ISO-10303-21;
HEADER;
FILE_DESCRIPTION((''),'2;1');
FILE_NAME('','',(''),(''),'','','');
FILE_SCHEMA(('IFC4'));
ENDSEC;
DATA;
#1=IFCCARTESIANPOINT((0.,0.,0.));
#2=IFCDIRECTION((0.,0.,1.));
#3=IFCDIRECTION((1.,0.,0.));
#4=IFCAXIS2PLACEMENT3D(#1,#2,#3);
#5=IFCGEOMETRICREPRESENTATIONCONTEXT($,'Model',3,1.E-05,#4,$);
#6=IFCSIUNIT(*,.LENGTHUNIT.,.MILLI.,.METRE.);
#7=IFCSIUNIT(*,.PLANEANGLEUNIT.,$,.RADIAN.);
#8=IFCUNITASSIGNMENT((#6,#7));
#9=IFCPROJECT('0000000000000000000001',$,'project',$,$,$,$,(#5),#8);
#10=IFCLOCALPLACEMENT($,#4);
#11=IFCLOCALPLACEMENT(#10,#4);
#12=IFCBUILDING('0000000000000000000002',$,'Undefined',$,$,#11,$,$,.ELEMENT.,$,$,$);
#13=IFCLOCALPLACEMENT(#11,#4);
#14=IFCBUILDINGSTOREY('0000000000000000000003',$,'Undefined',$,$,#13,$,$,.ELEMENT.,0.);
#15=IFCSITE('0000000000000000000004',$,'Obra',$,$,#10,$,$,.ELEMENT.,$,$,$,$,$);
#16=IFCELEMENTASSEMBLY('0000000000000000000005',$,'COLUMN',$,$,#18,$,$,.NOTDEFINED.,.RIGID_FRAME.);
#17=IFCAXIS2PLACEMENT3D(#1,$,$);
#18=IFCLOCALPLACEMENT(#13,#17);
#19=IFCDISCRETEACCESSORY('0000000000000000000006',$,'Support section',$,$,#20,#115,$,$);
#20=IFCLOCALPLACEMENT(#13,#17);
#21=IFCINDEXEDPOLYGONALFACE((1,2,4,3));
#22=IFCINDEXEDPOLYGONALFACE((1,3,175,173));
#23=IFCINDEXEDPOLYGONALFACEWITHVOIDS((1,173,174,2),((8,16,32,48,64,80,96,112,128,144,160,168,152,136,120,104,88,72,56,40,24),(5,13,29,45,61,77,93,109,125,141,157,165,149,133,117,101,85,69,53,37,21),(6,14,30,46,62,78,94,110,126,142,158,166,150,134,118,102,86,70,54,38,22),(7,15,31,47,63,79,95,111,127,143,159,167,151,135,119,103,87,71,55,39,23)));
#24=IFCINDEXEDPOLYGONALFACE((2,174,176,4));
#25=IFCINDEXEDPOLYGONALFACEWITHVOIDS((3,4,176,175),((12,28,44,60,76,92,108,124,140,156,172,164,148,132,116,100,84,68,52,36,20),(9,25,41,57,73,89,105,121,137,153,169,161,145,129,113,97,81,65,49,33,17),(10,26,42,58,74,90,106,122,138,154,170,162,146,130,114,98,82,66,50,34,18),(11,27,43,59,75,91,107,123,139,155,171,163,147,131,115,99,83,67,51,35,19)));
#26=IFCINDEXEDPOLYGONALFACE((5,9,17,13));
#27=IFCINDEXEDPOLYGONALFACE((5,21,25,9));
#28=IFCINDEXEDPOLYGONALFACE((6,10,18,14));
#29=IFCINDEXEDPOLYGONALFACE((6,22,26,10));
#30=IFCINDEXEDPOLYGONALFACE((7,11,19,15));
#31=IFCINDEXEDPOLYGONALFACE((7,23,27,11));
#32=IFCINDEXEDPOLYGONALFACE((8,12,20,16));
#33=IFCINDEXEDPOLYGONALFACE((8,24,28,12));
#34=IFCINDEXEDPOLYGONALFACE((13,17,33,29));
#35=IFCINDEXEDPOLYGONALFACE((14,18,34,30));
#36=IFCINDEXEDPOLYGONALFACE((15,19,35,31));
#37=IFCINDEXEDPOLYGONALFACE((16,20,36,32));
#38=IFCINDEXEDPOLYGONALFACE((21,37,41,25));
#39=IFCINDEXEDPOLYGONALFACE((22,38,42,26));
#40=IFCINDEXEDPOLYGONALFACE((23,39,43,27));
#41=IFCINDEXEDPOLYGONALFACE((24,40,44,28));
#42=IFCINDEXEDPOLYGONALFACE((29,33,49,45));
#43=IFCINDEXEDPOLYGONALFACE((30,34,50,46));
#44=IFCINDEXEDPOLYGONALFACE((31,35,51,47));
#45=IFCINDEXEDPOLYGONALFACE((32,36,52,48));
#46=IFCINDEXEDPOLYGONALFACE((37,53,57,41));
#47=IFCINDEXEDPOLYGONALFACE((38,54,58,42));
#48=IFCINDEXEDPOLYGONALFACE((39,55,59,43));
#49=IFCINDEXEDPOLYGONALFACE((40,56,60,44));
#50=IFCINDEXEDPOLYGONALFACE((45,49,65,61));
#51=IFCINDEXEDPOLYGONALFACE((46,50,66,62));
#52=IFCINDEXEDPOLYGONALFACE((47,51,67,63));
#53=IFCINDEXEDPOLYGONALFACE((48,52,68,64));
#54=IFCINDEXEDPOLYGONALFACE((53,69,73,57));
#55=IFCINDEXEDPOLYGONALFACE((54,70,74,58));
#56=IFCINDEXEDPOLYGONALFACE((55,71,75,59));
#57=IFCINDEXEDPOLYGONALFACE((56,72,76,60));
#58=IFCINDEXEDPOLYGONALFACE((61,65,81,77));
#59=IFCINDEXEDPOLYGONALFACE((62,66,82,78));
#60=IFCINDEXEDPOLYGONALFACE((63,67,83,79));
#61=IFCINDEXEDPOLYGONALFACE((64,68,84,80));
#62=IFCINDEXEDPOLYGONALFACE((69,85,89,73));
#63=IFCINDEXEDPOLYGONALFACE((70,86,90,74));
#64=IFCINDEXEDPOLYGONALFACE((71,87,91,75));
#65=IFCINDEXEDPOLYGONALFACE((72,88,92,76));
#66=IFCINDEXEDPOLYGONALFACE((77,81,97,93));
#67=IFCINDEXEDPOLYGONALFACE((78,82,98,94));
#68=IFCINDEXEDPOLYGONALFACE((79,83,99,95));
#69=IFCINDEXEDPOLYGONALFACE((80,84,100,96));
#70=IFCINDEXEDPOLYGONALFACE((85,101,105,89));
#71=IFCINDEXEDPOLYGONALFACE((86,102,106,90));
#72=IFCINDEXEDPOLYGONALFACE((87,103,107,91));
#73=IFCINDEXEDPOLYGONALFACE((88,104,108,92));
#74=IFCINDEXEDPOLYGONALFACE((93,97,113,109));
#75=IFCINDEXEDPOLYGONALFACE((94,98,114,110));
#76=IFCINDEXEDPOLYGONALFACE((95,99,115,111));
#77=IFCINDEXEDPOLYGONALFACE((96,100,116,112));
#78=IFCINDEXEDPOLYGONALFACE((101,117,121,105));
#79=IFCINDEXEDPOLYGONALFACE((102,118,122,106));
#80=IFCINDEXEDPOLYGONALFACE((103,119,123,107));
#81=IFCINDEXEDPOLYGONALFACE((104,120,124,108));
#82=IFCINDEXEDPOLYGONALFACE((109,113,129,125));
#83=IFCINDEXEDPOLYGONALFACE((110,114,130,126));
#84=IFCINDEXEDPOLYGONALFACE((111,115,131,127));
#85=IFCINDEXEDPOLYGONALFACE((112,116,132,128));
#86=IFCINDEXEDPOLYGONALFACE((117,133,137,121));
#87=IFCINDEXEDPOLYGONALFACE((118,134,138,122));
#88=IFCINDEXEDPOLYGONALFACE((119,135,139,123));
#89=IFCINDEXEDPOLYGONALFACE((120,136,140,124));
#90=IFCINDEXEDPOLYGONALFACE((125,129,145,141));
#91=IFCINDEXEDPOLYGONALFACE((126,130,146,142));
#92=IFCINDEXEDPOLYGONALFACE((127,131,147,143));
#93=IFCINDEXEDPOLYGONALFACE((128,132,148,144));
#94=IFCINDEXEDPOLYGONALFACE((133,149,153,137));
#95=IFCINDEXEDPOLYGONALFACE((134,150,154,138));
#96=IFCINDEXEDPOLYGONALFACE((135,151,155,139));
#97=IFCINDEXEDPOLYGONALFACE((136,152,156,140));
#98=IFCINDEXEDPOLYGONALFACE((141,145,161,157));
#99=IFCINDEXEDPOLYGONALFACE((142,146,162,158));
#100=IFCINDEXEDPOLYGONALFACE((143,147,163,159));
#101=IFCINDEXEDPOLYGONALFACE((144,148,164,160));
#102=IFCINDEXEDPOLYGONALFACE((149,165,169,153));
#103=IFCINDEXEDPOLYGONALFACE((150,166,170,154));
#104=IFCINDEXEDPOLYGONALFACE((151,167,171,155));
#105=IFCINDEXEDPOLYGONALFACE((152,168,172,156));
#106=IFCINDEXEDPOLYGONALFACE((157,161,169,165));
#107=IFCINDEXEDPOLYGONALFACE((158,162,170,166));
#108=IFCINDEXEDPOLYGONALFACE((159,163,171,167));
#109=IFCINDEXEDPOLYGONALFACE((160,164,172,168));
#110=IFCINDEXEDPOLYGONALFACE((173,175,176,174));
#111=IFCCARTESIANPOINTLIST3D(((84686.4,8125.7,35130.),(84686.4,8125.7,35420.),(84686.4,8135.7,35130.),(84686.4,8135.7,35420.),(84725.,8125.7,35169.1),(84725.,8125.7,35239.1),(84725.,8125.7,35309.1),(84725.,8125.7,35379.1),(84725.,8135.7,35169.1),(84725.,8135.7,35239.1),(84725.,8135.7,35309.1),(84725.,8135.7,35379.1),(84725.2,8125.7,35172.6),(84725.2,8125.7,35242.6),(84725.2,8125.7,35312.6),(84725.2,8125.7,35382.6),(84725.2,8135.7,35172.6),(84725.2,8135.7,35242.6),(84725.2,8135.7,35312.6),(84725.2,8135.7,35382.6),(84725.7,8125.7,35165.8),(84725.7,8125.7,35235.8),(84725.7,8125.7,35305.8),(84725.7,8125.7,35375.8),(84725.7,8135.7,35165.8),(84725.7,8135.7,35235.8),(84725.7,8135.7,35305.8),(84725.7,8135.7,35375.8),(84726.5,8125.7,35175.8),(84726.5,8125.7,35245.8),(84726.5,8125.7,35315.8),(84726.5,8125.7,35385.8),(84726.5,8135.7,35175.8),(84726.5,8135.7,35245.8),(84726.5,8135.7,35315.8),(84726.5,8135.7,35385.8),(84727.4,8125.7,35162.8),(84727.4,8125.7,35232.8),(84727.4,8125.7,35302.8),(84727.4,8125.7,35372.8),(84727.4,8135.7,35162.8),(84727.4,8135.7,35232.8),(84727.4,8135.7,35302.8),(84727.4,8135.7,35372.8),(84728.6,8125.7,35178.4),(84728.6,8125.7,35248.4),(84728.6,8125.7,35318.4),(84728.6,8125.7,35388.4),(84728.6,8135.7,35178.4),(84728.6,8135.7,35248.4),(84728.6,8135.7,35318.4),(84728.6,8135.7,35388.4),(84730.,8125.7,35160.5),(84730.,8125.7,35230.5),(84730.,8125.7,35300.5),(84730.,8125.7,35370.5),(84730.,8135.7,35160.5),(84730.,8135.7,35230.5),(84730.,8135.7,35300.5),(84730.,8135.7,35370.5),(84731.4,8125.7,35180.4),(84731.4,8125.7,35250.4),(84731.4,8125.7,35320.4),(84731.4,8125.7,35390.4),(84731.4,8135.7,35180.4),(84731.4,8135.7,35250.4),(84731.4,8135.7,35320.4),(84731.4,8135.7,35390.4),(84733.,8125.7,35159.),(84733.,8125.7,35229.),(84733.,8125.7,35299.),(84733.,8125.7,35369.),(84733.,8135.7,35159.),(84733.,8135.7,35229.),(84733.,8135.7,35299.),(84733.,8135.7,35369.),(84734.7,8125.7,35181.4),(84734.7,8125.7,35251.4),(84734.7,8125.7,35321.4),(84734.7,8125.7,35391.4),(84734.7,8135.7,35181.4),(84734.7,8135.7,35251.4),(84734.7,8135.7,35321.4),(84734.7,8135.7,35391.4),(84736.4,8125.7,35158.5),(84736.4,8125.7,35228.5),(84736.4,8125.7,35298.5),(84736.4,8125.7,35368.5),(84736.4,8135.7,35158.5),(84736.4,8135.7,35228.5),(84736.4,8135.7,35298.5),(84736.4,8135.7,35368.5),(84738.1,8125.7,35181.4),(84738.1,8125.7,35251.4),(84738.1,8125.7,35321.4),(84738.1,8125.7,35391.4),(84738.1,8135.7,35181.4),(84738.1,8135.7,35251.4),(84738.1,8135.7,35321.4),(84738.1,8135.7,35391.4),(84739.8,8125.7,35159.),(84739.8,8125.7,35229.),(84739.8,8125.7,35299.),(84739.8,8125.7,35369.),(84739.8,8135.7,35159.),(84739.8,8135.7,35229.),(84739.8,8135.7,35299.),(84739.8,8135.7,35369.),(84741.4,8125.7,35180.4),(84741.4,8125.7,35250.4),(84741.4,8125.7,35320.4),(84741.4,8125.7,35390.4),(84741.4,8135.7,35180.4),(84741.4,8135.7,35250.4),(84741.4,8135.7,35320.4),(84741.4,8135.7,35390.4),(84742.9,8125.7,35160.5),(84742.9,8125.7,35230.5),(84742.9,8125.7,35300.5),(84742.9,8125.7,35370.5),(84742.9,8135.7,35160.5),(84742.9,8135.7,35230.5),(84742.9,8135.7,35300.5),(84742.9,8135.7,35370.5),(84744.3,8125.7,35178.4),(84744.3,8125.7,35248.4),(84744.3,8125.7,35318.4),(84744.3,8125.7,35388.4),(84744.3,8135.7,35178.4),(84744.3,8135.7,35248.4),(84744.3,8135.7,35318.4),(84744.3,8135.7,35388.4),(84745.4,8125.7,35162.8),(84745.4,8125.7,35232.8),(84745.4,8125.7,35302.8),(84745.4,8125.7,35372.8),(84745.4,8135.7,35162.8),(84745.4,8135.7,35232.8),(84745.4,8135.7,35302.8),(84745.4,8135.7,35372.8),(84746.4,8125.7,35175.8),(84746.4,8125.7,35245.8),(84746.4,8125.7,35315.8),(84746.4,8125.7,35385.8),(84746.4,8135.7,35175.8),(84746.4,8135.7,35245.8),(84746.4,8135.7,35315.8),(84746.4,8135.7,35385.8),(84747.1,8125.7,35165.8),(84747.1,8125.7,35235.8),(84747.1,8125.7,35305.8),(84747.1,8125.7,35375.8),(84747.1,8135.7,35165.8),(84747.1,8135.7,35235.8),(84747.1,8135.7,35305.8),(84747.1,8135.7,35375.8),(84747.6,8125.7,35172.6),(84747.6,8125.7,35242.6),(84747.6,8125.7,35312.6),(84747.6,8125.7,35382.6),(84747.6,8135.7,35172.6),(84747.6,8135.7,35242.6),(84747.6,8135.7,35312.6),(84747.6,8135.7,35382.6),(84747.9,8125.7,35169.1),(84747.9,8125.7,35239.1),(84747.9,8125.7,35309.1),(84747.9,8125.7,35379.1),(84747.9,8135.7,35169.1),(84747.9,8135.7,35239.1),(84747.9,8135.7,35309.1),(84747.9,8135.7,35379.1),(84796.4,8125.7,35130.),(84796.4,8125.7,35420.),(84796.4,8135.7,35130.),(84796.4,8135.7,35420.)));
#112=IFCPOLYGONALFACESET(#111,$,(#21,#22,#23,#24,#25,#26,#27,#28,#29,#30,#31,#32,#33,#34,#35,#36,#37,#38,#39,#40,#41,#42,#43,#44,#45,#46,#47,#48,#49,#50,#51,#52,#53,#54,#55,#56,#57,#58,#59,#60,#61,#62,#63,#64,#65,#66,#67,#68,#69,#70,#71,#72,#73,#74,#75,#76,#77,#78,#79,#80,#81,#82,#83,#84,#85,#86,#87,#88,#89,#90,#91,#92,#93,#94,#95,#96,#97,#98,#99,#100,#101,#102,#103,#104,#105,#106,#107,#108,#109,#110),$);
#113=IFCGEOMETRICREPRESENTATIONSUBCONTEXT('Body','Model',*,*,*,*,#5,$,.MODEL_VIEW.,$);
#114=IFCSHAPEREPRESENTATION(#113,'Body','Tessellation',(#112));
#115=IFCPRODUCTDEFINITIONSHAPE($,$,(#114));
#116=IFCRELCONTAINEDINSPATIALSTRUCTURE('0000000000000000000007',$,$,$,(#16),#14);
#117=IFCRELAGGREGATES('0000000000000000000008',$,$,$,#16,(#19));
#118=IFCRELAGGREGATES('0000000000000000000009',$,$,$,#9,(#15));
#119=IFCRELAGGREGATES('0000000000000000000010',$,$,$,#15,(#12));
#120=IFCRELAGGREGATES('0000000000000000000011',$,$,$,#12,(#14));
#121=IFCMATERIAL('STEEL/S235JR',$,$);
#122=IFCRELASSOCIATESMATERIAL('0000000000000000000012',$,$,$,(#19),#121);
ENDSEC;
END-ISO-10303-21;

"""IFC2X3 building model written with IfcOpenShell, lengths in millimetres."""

from ifc_helpers import new_model, si_unit, frame, origin_with_axes, origin_2d_with_axis, place, context, subcontext, project, spatial, rectangle, circle, extrude, source, transform, mapped, material, element, aggregate, save


model = new_model("IFC2X3")

# Units and contexts
model_context = context("Model", 3, precision=1e-05, world=origin_with_axes())
body_context = subcontext(model_context, "Body", "Model", "MODEL_VIEW")
ifc_project = project(units=[si_unit("LENGTHUNIT", "METRE", prefix="MILLI"), si_unit("PLANEANGLEUNIT", "RADIAN")], contexts=[model_context])

# Site, building, storey
site_placement = place(None, origin_with_axes())
site = spatial("IfcSite", under=ifc_project, at=site_placement, Name="Obra", CompositionType="ELEMENT")
building_placement = place(site_placement, origin_with_axes())
building = spatial("IfcBuilding", under=site, at=building_placement, Name="Undefined", CompositionType="ELEMENT")
storey_placement = place(building_placement, origin_with_axes())
storey = spatial("IfcBuildingStorey", under=building, at=storey_placement, Name="Undefined", CompositionType="ELEMENT", Elevation=0.0)

# Element assembly
assembly_1_placement = place(storey_placement, origin_with_axes())
assembly_1 = element("IfcElementAssembly", 1, at=assembly_1_placement, inside=storey, Name="COLUMN", AssemblyPlace="NOTDEFINED", PredefinedType="RIGID_FRAME")
ifc_material_1 = material(Name="STEEL/S235JR")

# Discrete accessory, opening
shared_shape_1 = source(origin_with_axes(), body_context, "Body", "SweptSolid", [
    extrude(circle(Radius=11.5, at=origin_2d_with_axis()), frame((0.0, -15.6, 0.0), z_axis=(0.0, 1.0, 0.0), x_axis=(1.0, 0.0, 0.0)), (0.0, 0.0, 1.0), 10.2),
])
discrete_accessory_1_placement = place(assembly_1_placement, frame((84741.4, 8130.7, 35130.0), z_axis=(0.0, 0.0, 1.0), x_axis=(1.0, 0.0, 0.0)))
discrete_accessory_1 = element("IfcDiscreteAccessory", 2, at=discrete_accessory_1_placement, material=ifc_material_1, Name="Support section", context=body_context, shape_type="SweptSolid", body=[
    extrude(rectangle(XDim=10.0, YDim=110.0, at=origin_2d_with_axis()), frame((0.0, 0.0, 290.0), z_axis=(0.0, 0.0, -1.0), x_axis=(0.0, 1.0, 0.0)), (0.0, 0.0, 1.0), 290.0),
])
opening_1_placement = place(assembly_1_placement, frame((84786.4, 8120.2, 35470.0), z_axis=(-1.0, 0.0, 0.0), x_axis=(0.0, 0.0, -1.0)))
element("IfcOpeningElement", 3, at=opening_1_placement, cuts=discrete_accessory_1, ObjectType="Opening", context=body_context, shape_type="MappedRepresentation", body=[
    mapped(shared_shape_1, transform((90.0, 0.0, 50.0))),
    mapped(shared_shape_1, transform((160.0, 0.0, 50.0))),
    mapped(shared_shape_1, transform((230.0, 0.0, 50.0))),
    mapped(shared_shape_1, transform((300.0, 0.0, 50.0))),
])
aggregate(assembly_1, [discrete_accessory_1])

save(model, "model.ifc")
